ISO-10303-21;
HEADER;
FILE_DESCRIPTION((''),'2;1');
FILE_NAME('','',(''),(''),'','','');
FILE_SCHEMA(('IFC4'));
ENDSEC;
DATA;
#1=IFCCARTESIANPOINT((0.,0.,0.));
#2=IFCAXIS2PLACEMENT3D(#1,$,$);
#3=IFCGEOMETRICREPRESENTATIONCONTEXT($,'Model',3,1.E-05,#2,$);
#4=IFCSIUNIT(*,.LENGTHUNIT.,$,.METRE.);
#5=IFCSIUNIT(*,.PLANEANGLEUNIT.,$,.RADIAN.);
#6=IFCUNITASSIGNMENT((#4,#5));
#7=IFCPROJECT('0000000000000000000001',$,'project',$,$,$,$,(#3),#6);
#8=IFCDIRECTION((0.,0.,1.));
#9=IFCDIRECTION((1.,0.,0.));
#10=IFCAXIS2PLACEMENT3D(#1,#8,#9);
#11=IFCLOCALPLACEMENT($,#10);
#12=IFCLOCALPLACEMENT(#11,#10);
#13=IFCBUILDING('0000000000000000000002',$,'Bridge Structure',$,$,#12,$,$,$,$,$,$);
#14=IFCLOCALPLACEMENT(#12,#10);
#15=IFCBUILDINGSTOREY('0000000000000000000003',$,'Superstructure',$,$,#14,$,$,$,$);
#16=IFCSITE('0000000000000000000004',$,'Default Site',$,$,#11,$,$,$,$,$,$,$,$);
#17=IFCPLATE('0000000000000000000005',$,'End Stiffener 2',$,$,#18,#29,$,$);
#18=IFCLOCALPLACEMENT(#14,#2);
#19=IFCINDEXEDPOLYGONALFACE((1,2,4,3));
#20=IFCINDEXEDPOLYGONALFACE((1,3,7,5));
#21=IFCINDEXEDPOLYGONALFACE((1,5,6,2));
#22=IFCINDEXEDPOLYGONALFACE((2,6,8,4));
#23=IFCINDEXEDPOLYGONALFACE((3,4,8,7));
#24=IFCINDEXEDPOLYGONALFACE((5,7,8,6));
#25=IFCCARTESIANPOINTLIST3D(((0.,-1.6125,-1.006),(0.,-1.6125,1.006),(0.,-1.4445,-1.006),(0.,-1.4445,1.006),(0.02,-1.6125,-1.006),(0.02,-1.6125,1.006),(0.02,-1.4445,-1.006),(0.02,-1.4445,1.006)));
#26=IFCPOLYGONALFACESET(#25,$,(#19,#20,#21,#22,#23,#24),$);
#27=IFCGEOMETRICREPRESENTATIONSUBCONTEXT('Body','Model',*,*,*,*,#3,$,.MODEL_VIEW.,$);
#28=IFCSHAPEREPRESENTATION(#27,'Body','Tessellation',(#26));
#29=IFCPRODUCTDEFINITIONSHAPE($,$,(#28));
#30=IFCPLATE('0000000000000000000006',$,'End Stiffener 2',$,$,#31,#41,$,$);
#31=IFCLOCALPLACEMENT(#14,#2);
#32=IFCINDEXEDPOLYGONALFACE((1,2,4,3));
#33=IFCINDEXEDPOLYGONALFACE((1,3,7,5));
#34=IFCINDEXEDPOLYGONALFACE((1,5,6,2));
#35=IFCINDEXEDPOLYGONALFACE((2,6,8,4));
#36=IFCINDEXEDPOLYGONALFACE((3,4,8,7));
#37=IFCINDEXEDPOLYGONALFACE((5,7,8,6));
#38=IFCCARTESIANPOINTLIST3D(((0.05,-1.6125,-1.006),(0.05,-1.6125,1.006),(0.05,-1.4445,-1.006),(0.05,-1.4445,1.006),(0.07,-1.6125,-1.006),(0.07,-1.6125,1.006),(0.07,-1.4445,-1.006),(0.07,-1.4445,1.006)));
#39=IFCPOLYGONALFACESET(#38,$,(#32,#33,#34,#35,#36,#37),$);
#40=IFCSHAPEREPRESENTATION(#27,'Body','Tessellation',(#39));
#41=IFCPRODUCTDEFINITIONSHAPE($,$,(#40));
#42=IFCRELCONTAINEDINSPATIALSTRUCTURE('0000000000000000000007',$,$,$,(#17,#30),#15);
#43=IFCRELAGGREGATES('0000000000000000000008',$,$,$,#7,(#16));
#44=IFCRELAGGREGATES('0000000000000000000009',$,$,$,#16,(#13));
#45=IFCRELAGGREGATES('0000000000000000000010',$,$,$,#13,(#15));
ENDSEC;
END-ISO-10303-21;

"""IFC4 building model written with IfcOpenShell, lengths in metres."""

from ifc_helpers import new_model, si_unit, frame, origin, origin_with_axes, origin_2d_with_axis, place, context, subcontext, project, spatial, rectangle, extrude, element, save


model = new_model("IFC4")

# Units and contexts
model_context = context("Model", 3, precision=1e-05, world=origin())
body_context = subcontext(model_context, "Body", "Model", "MODEL_VIEW")
ifc_project = project(units=[si_unit("LENGTHUNIT", "METRE"), si_unit("PLANEANGLEUNIT", "RADIAN")], contexts=[model_context])

# Site, building, storey
site_placement = place(None, origin_with_axes())
site = spatial("IfcSite", under=ifc_project, at=site_placement, Name="Default Site")
building_placement = place(site_placement, origin_with_axes())
building = spatial("IfcBuilding", under=site, at=building_placement, Name="Bridge Structure")
storey_placement = place(building_placement, origin_with_axes())
storey = spatial("IfcBuildingStorey", under=building, at=storey_placement, Name="Superstructure")

# Plates
for number, where, z_axis, x_axis, name in (
    (1, (0.01, -1.5285, -1.006), (0.0, 0.0, 1.0), (1.0, 0.0, 0.0), "End Stiffener 2"),
    (2, (0.06, -1.5285, -1.006), (0.0, 0.0, 1.0), (1.0, 0.0, 0.0), "End Stiffener 2"),
):
    element("IfcPlate", number, at=place(storey_placement, frame(where, z_axis=z_axis, x_axis=x_axis)), inside=storey, Name=name, context=body_context, shape_type="SweptSolid", body=[
        extrude(rectangle(XDim=0.02, YDim=0.168, at=origin_2d_with_axis()), origin_with_axes(), (0.0, 0.0, 1.0), 2.012),
    ])

save(model, "model.ifc")
